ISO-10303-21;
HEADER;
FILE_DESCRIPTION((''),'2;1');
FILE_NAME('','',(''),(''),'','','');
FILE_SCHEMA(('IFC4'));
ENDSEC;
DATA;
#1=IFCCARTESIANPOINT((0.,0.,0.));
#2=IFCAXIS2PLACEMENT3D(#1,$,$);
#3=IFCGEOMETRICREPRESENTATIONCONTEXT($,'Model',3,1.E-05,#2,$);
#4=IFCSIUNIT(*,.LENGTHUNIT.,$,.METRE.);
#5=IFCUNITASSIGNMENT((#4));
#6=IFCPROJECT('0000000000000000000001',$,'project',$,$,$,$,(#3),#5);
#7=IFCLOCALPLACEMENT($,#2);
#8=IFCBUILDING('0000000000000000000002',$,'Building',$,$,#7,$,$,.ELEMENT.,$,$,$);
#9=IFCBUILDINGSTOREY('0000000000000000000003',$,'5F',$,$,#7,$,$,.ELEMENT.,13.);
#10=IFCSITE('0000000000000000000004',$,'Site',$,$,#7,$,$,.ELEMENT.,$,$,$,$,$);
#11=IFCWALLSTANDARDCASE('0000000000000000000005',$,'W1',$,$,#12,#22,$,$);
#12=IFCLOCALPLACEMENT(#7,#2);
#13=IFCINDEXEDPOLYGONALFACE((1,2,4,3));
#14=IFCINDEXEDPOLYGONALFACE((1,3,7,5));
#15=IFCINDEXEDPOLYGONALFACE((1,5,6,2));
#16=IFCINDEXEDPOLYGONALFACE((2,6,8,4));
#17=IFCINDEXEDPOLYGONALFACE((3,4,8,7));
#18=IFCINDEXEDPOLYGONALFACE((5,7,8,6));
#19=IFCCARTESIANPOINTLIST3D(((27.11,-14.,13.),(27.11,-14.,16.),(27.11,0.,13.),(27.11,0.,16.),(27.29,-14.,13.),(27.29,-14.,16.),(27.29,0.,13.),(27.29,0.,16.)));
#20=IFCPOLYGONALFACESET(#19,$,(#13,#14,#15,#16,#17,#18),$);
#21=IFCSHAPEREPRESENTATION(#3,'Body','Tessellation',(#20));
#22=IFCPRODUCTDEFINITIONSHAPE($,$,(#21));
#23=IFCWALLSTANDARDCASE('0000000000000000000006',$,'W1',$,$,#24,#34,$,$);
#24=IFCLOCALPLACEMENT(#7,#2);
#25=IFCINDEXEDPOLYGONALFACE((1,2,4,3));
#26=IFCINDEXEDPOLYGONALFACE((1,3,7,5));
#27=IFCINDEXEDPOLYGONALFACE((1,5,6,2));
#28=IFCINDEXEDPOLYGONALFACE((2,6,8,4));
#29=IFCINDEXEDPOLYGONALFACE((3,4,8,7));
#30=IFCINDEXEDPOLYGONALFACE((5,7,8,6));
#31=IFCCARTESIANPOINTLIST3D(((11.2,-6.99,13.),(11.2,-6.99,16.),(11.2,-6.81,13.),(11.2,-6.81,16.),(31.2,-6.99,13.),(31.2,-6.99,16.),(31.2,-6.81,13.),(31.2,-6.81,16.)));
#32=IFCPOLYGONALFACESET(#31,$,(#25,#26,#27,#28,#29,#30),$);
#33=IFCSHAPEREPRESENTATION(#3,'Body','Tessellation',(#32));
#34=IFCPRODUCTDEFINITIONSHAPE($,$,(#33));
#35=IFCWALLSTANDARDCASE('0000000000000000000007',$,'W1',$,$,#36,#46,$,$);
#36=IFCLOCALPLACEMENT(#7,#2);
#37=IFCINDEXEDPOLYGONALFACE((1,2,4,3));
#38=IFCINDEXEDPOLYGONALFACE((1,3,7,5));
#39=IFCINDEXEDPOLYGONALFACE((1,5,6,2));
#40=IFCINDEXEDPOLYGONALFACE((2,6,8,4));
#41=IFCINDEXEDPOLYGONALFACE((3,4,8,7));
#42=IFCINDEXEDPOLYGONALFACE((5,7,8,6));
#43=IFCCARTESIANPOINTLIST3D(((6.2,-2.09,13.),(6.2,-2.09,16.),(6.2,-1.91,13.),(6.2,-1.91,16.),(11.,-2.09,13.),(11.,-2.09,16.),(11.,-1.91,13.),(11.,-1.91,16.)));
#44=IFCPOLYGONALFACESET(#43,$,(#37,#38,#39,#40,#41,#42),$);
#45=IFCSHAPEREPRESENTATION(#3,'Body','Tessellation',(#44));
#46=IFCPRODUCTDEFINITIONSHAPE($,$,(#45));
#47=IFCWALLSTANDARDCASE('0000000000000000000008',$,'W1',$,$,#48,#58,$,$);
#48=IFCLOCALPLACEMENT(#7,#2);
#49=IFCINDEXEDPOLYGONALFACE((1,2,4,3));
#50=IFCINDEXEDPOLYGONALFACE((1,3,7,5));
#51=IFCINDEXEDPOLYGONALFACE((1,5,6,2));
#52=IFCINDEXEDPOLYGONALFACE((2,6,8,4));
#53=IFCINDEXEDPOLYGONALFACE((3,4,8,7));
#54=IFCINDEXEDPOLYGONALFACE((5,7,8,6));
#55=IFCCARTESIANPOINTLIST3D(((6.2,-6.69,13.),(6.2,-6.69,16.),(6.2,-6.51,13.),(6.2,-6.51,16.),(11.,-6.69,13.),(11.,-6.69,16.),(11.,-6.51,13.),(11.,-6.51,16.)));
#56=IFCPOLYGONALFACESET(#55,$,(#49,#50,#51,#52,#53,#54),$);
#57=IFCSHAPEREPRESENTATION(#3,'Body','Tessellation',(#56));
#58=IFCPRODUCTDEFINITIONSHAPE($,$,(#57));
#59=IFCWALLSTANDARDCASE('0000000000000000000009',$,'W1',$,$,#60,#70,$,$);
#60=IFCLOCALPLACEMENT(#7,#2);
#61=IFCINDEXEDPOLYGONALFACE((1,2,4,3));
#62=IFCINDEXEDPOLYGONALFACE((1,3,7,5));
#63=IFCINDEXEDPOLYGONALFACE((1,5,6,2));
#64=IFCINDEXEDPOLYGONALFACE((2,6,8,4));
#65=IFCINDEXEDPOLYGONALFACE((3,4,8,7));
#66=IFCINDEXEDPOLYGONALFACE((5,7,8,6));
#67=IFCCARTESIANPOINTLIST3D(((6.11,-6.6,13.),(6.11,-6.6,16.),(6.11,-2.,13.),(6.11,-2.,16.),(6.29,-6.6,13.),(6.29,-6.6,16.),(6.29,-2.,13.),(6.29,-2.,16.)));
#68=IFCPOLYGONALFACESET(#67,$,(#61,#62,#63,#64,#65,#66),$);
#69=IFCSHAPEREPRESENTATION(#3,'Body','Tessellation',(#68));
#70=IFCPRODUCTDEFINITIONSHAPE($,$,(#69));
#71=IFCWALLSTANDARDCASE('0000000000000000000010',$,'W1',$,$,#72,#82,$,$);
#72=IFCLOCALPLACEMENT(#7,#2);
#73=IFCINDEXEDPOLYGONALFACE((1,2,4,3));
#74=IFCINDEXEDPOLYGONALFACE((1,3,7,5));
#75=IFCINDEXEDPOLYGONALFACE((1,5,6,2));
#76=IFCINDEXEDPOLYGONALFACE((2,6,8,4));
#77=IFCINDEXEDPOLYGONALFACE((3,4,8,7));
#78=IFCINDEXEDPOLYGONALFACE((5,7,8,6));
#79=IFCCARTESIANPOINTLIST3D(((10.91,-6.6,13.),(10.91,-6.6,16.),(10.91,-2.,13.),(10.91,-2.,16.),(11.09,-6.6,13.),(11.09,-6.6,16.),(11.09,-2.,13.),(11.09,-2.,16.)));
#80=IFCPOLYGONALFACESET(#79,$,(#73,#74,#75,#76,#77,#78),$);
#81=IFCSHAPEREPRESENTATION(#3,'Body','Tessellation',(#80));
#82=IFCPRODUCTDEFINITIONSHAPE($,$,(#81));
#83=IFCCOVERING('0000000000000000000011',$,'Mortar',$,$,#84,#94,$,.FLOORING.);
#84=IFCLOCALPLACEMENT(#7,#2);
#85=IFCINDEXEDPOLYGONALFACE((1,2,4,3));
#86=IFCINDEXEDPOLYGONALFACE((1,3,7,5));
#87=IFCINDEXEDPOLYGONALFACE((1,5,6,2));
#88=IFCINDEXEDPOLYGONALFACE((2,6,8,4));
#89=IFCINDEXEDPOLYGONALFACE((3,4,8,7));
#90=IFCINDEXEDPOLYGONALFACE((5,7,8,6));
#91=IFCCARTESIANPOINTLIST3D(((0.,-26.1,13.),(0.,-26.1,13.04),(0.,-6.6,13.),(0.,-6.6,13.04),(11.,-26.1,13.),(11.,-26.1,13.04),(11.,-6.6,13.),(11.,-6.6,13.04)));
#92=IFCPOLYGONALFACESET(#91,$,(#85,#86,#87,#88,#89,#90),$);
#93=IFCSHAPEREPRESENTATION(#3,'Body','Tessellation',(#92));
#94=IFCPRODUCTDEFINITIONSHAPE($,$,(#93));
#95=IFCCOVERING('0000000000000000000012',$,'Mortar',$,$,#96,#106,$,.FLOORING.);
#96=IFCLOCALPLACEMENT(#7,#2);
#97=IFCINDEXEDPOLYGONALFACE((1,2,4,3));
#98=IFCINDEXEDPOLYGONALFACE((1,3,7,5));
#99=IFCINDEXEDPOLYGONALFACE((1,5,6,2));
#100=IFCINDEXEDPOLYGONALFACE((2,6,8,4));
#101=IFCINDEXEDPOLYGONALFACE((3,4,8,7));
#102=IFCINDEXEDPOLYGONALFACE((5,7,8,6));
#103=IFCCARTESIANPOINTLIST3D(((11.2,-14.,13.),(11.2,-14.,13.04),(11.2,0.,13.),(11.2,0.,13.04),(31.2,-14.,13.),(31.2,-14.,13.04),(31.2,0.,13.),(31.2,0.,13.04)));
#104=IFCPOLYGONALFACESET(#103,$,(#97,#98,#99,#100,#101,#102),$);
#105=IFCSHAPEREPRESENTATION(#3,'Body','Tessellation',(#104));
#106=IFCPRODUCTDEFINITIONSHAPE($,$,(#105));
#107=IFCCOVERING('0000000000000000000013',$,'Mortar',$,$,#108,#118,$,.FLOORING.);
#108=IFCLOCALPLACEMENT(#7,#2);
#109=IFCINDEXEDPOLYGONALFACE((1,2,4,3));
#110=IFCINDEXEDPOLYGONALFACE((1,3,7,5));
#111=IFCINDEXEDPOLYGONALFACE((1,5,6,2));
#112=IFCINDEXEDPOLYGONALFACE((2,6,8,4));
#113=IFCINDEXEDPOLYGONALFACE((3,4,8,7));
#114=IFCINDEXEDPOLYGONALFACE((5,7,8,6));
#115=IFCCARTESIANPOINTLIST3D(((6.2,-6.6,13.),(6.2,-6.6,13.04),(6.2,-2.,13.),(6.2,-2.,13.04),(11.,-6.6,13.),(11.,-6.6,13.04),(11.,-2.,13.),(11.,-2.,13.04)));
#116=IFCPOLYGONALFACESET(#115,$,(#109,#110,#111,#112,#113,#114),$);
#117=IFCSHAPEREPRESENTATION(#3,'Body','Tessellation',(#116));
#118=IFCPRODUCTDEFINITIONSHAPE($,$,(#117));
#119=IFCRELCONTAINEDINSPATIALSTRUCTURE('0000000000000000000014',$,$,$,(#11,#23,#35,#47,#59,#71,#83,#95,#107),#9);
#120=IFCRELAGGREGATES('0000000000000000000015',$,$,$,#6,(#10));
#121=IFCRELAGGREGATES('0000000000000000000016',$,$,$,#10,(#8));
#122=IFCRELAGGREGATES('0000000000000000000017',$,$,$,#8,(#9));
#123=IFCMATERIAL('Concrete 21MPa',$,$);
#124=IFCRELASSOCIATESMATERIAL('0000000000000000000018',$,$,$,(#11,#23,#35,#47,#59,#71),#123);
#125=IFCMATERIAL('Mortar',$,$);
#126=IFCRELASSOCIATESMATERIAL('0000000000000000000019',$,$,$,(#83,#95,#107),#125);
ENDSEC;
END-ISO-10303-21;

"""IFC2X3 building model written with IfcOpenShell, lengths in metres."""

from ifc_helpers import new_model, si_unit, frame, origin, origin_2d, place, context, project, spatial, rectangle, extrude, material, element, save


model = new_model("IFC2X3")

# Units and contexts
model_context = context("Model", 3, precision=1e-05, world=origin())
ifc_project = project(units=[si_unit("LENGTHUNIT", "METRE")], contexts=[model_context])

# Site, building, storey
placement = place(None, origin())
site = spatial("IfcSite", under=ifc_project, at=placement, Name="Site", CompositionType="ELEMENT")
building = spatial("IfcBuilding", under=site, at=placement, Name="Building", CompositionType="ELEMENT")
storey = spatial("IfcBuildingStorey", under=building, at=placement, Name="5F", CompositionType="ELEMENT", Elevation=13.0)

# Shared definitions
ifc_material_1 = material(Name="Concrete 21MPa")

# Walls
for number, where, name in (
    (1, (27.2, -7.0, 13.0), "W1"),
):
    element("IfcWallStandardCase", number, at=place(None, frame(where)), inside=storey, material=ifc_material_1, Name=name, context=model_context, shape_type="SweptSolid", body=[
        extrude(rectangle(XDim=0.18, YDim=14.0, at=origin_2d()), origin(), (0.0, 0.0, 1.0), 3.0),
    ])
wall_1_placement = place(None, frame((21.2, -6.9, 13.0)))
element("IfcWallStandardCase", 2, at=wall_1_placement, inside=storey, material=ifc_material_1, Name="W1", context=model_context, shape_type="SweptSolid", body=[
    extrude(rectangle(XDim=20.0, YDim=0.18, at=origin_2d()), origin(), (0.0, 0.0, 1.0), 3.0),
])
for number, where, name in (
    (3, (8.6, -2.0, 13.0), "W1"),
    (4, (8.6, -6.6, 13.0), "W1"),
):
    element("IfcWallStandardCase", number, at=place(None, frame(where)), inside=storey, material=ifc_material_1, Name=name, context=model_context, shape_type="SweptSolid", body=[
        extrude(rectangle(XDim=4.8, YDim=0.18, at=origin_2d()), origin(), (0.0, 0.0, 1.0), 3.0),
    ])
for number, where, name in (
    (5, (6.2, -4.3, 13.0), "W1"),
    (6, (11.0, -4.3, 13.0), "W1"),
):
    element("IfcWallStandardCase", number, at=place(None, frame(where)), inside=storey, material=ifc_material_1, Name=name, context=model_context, shape_type="SweptSolid", body=[
        extrude(rectangle(XDim=0.18, YDim=4.6, at=origin_2d()), origin(), (0.0, 0.0, 1.0), 3.0),
    ])

# Coverings
ifc_material_2 = material(Name="Mortar")
covering_1_placement = place(None, frame((5.5, -16.35, 13.0)))
element("IfcCovering", 7, at=covering_1_placement, inside=storey, material=ifc_material_2, Name="Mortar", PredefinedType="FLOORING", context=model_context, shape_type="SweptSolid", body=[
    extrude(rectangle(XDim=11.0, YDim=19.5, at=origin_2d()), origin(), (0.0, 0.0, 1.0), 0.04),
])
covering_2_placement = place(None, frame((21.2, -7.0, 13.0)))
element("IfcCovering", 8, at=covering_2_placement, inside=storey, material=ifc_material_2, Name="Mortar", PredefinedType="FLOORING", context=model_context, shape_type="SweptSolid", body=[
    extrude(rectangle(XDim=20.0, YDim=14.0, at=origin_2d()), origin(), (0.0, 0.0, 1.0), 0.04),
])
covering_3_placement = place(None, frame((8.6, -4.3, 13.0)))
element("IfcCovering", 9, at=covering_3_placement, inside=storey, material=ifc_material_2, Name="Mortar", PredefinedType="FLOORING", context=model_context, shape_type="SweptSolid", body=[
    extrude(rectangle(XDim=4.8, YDim=4.6, at=origin_2d()), origin(), (0.0, 0.0, 1.0), 0.04),
])

save(model, "model.ifc")
